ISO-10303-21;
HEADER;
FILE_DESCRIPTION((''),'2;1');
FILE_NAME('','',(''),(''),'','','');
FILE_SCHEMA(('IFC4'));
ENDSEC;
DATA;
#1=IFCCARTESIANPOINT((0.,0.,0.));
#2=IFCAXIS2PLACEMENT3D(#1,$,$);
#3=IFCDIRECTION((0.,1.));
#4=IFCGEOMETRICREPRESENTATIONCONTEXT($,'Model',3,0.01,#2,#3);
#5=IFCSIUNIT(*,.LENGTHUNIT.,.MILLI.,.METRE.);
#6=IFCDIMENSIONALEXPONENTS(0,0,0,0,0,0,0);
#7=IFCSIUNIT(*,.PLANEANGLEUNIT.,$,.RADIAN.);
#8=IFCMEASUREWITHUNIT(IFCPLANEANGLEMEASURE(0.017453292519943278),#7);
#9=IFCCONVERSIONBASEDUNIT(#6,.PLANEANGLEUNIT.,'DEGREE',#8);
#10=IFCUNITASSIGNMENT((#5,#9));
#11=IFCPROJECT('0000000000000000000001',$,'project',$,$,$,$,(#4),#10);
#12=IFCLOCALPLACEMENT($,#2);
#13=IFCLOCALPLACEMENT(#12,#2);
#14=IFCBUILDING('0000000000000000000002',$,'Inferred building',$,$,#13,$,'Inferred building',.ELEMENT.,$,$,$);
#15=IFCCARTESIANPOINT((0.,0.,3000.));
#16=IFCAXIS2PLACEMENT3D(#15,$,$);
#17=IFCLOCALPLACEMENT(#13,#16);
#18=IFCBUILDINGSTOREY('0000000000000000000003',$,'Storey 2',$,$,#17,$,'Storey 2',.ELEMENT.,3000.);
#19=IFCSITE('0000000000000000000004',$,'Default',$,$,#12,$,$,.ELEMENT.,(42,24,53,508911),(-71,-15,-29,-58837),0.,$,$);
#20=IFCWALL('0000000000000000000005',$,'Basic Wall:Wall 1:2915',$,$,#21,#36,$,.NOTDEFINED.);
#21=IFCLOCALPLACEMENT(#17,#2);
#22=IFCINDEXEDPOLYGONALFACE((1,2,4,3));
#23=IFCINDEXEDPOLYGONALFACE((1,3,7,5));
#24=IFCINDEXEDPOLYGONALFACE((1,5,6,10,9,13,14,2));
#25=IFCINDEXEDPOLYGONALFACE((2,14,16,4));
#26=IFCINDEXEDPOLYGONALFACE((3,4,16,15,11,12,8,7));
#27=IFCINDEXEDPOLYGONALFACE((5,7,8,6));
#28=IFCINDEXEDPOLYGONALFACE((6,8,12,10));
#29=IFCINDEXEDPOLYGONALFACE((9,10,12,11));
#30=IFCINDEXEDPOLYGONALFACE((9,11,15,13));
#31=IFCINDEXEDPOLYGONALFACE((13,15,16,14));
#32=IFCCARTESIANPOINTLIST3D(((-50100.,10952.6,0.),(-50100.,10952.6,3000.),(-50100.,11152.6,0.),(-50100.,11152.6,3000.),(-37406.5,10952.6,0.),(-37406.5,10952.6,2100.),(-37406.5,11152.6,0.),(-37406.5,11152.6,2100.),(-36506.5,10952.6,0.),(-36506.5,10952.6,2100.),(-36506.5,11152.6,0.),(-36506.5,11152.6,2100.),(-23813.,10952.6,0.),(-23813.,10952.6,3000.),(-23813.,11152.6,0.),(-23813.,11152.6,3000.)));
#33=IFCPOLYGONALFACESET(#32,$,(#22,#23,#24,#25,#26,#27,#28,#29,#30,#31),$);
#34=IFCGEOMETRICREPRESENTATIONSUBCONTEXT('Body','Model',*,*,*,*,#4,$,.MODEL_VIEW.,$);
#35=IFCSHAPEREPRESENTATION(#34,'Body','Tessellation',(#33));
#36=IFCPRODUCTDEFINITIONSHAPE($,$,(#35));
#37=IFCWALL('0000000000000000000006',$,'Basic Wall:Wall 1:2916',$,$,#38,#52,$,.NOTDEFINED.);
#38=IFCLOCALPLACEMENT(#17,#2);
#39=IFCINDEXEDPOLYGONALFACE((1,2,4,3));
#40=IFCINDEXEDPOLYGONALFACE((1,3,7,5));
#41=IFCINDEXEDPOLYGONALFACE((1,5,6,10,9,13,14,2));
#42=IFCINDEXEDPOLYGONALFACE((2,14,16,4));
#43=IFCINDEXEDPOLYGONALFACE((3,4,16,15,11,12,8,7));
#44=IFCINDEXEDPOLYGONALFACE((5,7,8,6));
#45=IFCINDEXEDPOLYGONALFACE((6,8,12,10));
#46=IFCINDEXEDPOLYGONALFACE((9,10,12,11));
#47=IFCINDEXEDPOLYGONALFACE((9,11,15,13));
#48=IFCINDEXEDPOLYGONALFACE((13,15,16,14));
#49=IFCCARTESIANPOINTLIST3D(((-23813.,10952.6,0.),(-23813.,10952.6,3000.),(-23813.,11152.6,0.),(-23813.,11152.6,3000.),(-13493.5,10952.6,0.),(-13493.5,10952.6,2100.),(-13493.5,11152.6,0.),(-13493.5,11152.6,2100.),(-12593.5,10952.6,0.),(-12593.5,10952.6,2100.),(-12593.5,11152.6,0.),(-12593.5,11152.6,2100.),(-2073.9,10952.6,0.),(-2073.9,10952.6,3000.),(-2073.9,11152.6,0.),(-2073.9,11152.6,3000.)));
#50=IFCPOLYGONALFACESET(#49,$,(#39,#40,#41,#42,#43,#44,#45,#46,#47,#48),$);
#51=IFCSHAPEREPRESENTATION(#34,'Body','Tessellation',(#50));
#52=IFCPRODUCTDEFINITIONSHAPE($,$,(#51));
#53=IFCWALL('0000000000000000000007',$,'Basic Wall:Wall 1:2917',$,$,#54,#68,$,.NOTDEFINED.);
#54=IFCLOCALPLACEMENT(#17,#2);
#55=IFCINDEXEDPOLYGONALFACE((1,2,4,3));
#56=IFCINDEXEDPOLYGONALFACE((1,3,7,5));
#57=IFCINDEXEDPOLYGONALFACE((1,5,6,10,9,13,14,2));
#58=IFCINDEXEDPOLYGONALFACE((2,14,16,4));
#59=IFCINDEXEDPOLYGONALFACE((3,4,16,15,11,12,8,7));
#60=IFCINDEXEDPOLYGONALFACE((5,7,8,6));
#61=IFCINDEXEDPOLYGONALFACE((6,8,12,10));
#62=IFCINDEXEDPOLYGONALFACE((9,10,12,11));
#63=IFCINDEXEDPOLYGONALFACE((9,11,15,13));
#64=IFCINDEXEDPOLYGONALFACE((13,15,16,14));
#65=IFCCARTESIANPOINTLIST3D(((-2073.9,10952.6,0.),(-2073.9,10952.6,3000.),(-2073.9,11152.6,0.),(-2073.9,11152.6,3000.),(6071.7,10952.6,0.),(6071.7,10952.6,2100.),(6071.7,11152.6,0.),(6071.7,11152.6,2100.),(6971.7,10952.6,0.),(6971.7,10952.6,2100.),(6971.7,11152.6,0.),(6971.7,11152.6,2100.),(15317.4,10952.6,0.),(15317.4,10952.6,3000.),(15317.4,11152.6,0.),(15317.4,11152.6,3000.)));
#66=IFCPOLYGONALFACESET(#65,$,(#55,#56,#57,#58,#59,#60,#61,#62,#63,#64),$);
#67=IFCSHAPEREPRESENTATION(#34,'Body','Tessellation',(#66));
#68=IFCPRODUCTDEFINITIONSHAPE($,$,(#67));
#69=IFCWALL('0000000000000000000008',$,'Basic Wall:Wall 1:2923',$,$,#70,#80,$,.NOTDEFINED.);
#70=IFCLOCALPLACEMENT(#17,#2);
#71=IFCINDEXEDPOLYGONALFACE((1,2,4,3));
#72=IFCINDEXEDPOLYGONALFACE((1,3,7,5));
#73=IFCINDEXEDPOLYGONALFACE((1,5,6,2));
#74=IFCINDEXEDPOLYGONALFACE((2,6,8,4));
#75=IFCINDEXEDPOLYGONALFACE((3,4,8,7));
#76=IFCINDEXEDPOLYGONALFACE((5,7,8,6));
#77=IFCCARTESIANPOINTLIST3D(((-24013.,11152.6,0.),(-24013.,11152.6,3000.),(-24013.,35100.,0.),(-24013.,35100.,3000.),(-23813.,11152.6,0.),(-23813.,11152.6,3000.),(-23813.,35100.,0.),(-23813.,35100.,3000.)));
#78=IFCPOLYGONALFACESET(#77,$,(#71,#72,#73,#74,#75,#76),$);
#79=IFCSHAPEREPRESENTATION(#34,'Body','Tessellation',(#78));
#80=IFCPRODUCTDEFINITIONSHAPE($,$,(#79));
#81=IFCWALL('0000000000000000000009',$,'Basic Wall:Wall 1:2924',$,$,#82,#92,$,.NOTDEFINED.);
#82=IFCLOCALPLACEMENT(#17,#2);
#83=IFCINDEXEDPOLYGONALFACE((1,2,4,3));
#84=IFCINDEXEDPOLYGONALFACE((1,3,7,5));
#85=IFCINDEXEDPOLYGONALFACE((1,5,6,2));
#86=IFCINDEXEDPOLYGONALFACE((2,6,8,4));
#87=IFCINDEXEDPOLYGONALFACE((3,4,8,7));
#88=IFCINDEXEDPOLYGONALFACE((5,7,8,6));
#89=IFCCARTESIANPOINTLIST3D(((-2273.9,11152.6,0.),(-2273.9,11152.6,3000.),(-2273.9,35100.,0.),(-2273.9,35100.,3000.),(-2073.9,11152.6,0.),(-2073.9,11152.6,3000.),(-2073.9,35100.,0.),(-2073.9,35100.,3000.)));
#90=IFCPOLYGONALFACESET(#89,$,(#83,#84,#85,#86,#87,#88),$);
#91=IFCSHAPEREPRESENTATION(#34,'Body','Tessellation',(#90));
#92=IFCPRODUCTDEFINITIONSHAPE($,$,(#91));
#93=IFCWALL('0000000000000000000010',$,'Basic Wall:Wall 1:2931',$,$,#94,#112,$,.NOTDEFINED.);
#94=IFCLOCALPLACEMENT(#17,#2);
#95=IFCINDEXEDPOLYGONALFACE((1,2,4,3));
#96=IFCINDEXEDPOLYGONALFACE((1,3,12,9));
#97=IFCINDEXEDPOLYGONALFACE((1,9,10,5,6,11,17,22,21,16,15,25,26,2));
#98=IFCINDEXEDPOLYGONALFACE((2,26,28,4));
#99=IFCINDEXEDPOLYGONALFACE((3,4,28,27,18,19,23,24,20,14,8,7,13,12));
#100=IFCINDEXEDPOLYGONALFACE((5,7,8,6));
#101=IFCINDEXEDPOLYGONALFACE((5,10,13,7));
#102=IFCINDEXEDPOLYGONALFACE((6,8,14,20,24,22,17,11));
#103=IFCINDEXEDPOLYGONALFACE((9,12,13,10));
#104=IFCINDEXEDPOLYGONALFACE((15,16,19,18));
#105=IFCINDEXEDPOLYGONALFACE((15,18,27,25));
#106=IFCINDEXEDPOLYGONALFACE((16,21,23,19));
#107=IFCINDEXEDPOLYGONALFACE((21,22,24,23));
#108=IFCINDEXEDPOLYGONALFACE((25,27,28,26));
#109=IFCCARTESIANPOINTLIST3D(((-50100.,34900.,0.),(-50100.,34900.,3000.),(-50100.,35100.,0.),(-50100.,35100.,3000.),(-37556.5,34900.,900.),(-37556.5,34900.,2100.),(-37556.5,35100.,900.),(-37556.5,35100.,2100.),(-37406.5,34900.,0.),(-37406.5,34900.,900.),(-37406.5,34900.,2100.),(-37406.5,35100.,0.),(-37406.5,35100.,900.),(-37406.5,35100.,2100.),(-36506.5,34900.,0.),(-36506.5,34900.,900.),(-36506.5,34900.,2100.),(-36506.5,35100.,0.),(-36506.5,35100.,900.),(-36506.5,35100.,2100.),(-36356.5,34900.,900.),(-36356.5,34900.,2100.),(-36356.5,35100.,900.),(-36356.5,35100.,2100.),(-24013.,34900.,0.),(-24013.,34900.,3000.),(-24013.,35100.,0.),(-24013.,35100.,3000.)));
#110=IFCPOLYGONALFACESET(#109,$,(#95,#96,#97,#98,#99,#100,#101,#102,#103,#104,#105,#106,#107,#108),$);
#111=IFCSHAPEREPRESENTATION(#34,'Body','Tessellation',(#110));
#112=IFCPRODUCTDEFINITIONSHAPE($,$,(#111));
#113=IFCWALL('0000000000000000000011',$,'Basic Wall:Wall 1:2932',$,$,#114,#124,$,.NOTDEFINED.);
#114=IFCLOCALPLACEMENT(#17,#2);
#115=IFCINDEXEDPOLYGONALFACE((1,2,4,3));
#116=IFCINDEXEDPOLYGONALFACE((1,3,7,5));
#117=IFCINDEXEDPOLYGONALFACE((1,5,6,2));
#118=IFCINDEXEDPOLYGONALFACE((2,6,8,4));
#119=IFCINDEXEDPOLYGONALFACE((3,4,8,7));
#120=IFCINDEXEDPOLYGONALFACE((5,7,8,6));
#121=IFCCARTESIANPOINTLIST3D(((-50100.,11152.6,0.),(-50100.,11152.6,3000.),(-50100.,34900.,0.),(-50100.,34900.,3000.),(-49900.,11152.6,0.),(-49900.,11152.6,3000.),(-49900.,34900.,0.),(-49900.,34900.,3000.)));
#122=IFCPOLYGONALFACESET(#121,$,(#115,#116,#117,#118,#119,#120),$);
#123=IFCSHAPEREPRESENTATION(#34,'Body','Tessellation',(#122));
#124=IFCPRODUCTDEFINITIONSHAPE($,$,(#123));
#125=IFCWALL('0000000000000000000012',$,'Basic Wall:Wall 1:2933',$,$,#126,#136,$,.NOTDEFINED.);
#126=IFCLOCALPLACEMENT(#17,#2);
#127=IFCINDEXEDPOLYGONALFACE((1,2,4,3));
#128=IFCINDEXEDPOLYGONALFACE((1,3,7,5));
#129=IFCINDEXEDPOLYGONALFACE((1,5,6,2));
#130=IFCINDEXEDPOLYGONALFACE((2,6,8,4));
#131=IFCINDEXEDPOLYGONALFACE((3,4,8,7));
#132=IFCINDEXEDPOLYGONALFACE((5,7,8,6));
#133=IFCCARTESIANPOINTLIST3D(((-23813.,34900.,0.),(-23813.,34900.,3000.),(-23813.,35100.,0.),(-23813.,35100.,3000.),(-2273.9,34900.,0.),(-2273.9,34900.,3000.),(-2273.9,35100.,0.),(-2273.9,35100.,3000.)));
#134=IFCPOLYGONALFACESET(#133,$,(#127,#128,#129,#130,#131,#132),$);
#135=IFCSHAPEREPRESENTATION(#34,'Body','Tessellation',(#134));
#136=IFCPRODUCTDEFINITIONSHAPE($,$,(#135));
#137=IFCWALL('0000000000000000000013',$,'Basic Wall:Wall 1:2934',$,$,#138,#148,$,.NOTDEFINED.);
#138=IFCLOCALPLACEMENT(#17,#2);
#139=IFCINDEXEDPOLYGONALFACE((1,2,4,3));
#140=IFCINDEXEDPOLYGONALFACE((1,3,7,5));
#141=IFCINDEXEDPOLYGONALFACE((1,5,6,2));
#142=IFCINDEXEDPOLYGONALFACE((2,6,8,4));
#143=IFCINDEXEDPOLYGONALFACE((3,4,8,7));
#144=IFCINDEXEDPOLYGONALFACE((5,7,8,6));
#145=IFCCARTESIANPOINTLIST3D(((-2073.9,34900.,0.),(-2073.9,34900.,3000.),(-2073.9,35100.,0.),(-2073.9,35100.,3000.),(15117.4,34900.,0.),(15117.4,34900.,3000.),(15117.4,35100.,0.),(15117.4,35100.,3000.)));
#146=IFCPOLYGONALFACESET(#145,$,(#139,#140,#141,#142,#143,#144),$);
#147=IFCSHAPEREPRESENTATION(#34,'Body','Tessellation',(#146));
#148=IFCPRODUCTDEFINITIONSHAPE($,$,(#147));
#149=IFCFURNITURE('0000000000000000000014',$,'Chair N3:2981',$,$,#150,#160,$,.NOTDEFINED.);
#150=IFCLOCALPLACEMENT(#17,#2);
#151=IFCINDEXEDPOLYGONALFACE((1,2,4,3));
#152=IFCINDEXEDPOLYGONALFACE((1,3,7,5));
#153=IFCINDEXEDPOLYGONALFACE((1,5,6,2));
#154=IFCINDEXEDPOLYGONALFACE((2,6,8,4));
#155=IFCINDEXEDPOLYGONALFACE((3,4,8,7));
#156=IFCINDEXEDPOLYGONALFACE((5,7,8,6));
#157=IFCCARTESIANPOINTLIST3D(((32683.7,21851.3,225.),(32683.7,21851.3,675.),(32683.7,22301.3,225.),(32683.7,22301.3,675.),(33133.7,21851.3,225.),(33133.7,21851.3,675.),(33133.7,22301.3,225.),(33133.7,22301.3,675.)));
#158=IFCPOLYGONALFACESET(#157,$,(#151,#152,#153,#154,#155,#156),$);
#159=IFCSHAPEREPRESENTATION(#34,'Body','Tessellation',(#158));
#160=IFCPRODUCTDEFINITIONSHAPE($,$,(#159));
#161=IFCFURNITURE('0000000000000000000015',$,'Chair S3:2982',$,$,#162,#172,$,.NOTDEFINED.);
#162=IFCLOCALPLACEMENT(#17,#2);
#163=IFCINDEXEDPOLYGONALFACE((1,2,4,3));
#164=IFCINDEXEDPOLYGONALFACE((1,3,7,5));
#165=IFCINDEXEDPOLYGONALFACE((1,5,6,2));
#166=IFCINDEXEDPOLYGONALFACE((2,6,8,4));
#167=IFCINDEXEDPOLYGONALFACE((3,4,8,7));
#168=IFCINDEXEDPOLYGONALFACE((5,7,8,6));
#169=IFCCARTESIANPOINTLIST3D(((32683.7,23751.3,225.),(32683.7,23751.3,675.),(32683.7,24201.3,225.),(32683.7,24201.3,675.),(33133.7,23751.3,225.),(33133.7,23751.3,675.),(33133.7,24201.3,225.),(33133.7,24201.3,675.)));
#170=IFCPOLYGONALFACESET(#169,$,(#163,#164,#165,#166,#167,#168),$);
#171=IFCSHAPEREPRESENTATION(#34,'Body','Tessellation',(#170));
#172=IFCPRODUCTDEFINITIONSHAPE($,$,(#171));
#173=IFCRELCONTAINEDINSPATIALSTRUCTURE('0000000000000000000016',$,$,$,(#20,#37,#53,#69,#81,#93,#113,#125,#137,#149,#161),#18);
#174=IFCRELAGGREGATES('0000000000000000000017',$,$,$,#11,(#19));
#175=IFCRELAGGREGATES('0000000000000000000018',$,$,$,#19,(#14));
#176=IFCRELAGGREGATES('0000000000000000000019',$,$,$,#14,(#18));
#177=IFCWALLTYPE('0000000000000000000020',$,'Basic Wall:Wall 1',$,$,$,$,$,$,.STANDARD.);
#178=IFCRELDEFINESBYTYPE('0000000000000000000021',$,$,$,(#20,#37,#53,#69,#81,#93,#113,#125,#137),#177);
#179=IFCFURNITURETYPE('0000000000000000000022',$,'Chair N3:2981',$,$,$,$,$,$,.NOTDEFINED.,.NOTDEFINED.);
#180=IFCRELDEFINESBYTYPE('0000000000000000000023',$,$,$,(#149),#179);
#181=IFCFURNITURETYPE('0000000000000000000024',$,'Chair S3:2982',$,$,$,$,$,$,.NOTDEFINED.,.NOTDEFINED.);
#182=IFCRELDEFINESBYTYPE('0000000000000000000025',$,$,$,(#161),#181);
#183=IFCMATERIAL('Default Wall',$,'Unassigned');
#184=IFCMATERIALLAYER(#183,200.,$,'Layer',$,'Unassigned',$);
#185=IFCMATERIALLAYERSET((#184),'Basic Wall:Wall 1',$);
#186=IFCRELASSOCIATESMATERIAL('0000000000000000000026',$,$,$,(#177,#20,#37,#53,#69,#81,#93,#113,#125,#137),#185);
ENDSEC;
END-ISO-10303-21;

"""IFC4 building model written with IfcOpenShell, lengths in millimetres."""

from ifc_helpers import new_model, entity, si_unit, converted_unit, direction, frame, frame_2d, origin, origin_2d_with_axis, place, context, subcontext, project, spatial, rectangle, extrude, material, layer, layer_set, layer_usage, type_object, element, save


model = new_model("IFC4")

# Units and contexts
model_context = context("Model", 3, precision=0.01, world=origin(), true_north=direction((0.0, 1.0)))
body_context = subcontext(model_context, "Body", "Model", "MODEL_VIEW")
ifc_project = project(units=[si_unit("LENGTHUNIT", "METRE", prefix="MILLI"), converted_unit("PLANEANGLEUNIT", "DEGREE", entity("IfcPlaneAngleMeasure", 0.017453292519943278), si_unit("PLANEANGLEUNIT", "RADIAN"), dimensions=[0, 0, 0, 0, 0, 0, 0])], contexts=[model_context])

# Site, building, storey
site_placement = place(None, origin())
site = spatial("IfcSite", under=ifc_project, at=site_placement, Name="Default", CompositionType="ELEMENT", RefLatitude=(42, 24, 53, 508911), RefLongitude=(-71, -15, -29, -58837), RefElevation=0.0)
building_placement = place(site_placement, origin())
building = spatial("IfcBuilding", under=site, at=building_placement, Name="Inferred building", LongName="Inferred building", CompositionType="ELEMENT")
storey_placement = place(building_placement, frame((0.0, 0.0, 3000.0)))
storey = spatial("IfcBuildingStorey", under=building, at=storey_placement, Name="Storey 2", LongName="Storey 2", CompositionType="ELEMENT", Elevation=3000.0)

# Walls, openings
ifc_material = material(Name="Default Wall", Category="Unassigned")
ifc_layer = layer(ifc_material, 200.0, Name="Layer", Category="Unassigned")
ifc_layer_set = layer_set([ifc_layer], Name="Basic Wall:Wall 1")
ifc_layer_usage_1 = layer_usage(ifc_layer_set, "AXIS2", "NEGATIVE", 100.0)
wall_type = type_object("IfcWallType", Name="Basic Wall:Wall 1", PredefinedType="STANDARD", material=ifc_layer_set)
wall_1_placement = place(storey_placement, frame((-50100.0, 11052.6, 0.0)))
wall_1 = element("IfcWall", 1, at=wall_1_placement, inside=storey, type_object=wall_type, material=ifc_layer_usage_1, Name="Basic Wall:Wall 1:2915", PredefinedType="NOTDEFINED", context=body_context, shape_type="SweptSolid", body=[
    extrude(rectangle(XDim=26287.0, YDim=200.0, at=frame_2d((13143.5, 0.0), x_axis=(1.0, 0.0))), origin(), (0.0, 0.0, 1.0), 3000.0),
])
opening_1_placement = place(wall_1_placement, origin())
element("IfcOpeningElement", 2, at=opening_1_placement, cuts=wall_1, PredefinedType="OPENING", context=body_context, shape_type="SweptSolid", body=[
    extrude(rectangle(XDim=2100.0, YDim=900.0, at=frame_2d((0.0, 0.0), x_axis=(1.0, 0.0))), frame((13143.5, -100.0, 1050.0), z_axis=(0.0, 1.0, 0.0), x_axis=(0.0, 0.0, -1.0)), (0.0, 0.0, 1.0), 200.0),
])
ifc_layer_usage_2 = layer_usage(ifc_layer_set, "AXIS2", "NEGATIVE", 100.0)
wall_2_placement = place(storey_placement, frame((-23813.0, 11052.6, 0.0)))
wall_2 = element("IfcWall", 3, at=wall_2_placement, inside=storey, type_object=wall_type, material=ifc_layer_usage_2, Name="Basic Wall:Wall 1:2916", PredefinedType="NOTDEFINED", context=body_context, shape_type="SweptSolid", body=[
    extrude(rectangle(XDim=21739.1, YDim=200.0, at=frame_2d((10869.6, 0.0), x_axis=(1.0, 0.0))), origin(), (0.0, 0.0, 1.0), 3000.0),
])
opening_2_placement = place(wall_2_placement, origin())
element("IfcOpeningElement", 4, at=opening_2_placement, cuts=wall_2, PredefinedType="OPENING", context=body_context, shape_type="SweptSolid", body=[
    extrude(rectangle(XDim=2100.0, YDim=900.0, at=frame_2d((0.0, 0.0), x_axis=(1.0, 0.0))), frame((10769.6, -100.0, 1050.0), z_axis=(0.0, 1.0, 0.0), x_axis=(0.0, 0.0, -1.0)), (0.0, 0.0, 1.0), 200.0),
])
ifc_layer_usage_3 = layer_usage(ifc_layer_set, "AXIS2", "NEGATIVE", 100.0)
wall_3_placement = place(storey_placement, frame((-2073.9, 11052.6, 0.0)))
wall_3 = element("IfcWall", 5, at=wall_3_placement, inside=storey, type_object=wall_type, material=ifc_layer_usage_3, Name="Basic Wall:Wall 1:2917", PredefinedType="NOTDEFINED", context=body_context, shape_type="SweptSolid", body=[
    extrude(rectangle(XDim=17391.3, YDim=200.0, at=frame_2d((8695.7, 0.0), x_axis=(1.0, 0.0))), origin(), (0.0, 0.0, 1.0), 3000.0),
])
opening_3_placement = place(wall_3_placement, origin())
element("IfcOpeningElement", 6, at=opening_3_placement, cuts=wall_3, PredefinedType="OPENING", context=body_context, shape_type="SweptSolid", body=[
    extrude(rectangle(XDim=2100.0, YDim=900.0, at=frame_2d((0.0, 0.0), x_axis=(1.0, 0.0))), frame((8595.7, -100.0, 1050.0), z_axis=(0.0, 1.0, 0.0), x_axis=(0.0, 0.0, -1.0)), (0.0, 0.0, 1.0), 200.0),
])

# Walls
ifc_layer_usage_4 = layer_usage(ifc_layer_set, "AXIS2", "NEGATIVE", 100.0)
wall_4_placement = place(storey_placement, frame((-23913.0, 11152.6, 0.0), z_axis=(0.0, 0.0, 1.0), x_axis=(0.0, 1.0, 0.0)))
element("IfcWall", 7, at=wall_4_placement, inside=storey, type_object=wall_type, material=ifc_layer_usage_4, Name="Basic Wall:Wall 1:2923", PredefinedType="NOTDEFINED", context=body_context, shape_type="SweptSolid", body=[
    extrude(rectangle(XDim=23947.4, YDim=200.0, at=frame_2d((11973.7, 0.0), x_axis=(-1.0, 0.0))), origin(), (0.0, 0.0, 1.0), 3000.0),
])
ifc_layer_usage_5 = layer_usage(ifc_layer_set, "AXIS2", "NEGATIVE", 100.0)
wall_5_placement = place(storey_placement, frame((-2173.9, 11152.6, 0.0), z_axis=(0.0, 0.0, 1.0), x_axis=(0.0, 1.0, 0.0)))
element("IfcWall", 8, at=wall_5_placement, inside=storey, type_object=wall_type, material=ifc_layer_usage_5, Name="Basic Wall:Wall 1:2924", PredefinedType="NOTDEFINED", context=body_context, shape_type="SweptSolid", body=[
    extrude(rectangle(XDim=23947.4, YDim=200.0, at=frame_2d((11973.7, 0.0), x_axis=(-1.0, 0.0))), origin(), (0.0, 0.0, 1.0), 3000.0),
])

# Wall, openings
ifc_layer_usage_6 = layer_usage(ifc_layer_set, "AXIS2", "NEGATIVE", 100.0)
wall_6_placement = place(storey_placement, frame((-50100.0, 35000.0, 0.0)))
wall_6 = element("IfcWall", 9, at=wall_6_placement, inside=storey, type_object=wall_type, material=ifc_layer_usage_6, Name="Basic Wall:Wall 1:2931", PredefinedType="NOTDEFINED", context=body_context, shape_type="SweptSolid", body=[
    extrude(rectangle(XDim=26087.0, YDim=200.0, at=frame_2d((13043.5, 0.0), x_axis=(1.0, 0.0))), origin(), (0.0, 0.0, 1.0), 3000.0),
])
opening_4_placement = place(wall_6_placement, origin())
element("IfcOpeningElement", 10, at=opening_4_placement, cuts=wall_6, PredefinedType="OPENING", context=body_context, shape_type="SweptSolid", body=[
    extrude(rectangle(XDim=2100.0, YDim=900.0, at=frame_2d((0.0, 0.0), x_axis=(1.0, 0.0))), frame((13143.5, -100.0, 1050.0), z_axis=(0.0, 1.0, 0.0), x_axis=(0.0, 0.0, -1.0)), (0.0, 0.0, 1.0), 200.0),
])
opening_5_placement = place(wall_6_placement, origin())
element("IfcOpeningElement", 11, at=opening_5_placement, cuts=wall_6, PredefinedType="OPENING", context=body_context, shape_type="SweptSolid", body=[
    extrude(rectangle(XDim=1200.0, YDim=1200.0, at=frame_2d((0.0, 0.0), x_axis=(1.0, 0.0))), frame((13143.5, -100.0, 1500.0), z_axis=(0.0, 1.0, 0.0), x_axis=(0.0, 0.0, -1.0)), (0.0, 0.0, 1.0), 200.0),
])

# Walls
ifc_layer_usage_7 = layer_usage(ifc_layer_set, "AXIS2", "NEGATIVE", 100.0)
wall_7_placement = place(storey_placement, frame((-50000.0, 11152.6, 0.0), z_axis=(0.0, 0.0, 1.0), x_axis=(0.0, 1.0, 0.0)))
element("IfcWall", 12, at=wall_7_placement, inside=storey, type_object=wall_type, material=ifc_layer_usage_7, Name="Basic Wall:Wall 1:2932", PredefinedType="NOTDEFINED", context=body_context, shape_type="SweptSolid", body=[
    extrude(rectangle(XDim=23747.4, YDim=200.0, at=frame_2d((11873.7, 0.0), x_axis=(-1.0, 0.0))), origin(), (0.0, 0.0, 1.0), 3000.0),
])
ifc_layer_usage_8 = layer_usage(ifc_layer_set, "AXIS2", "NEGATIVE", 100.0)
wall_8_placement = place(storey_placement, frame((-23813.0, 35000.0, 0.0)))
element("IfcWall", 13, at=wall_8_placement, inside=storey, type_object=wall_type, material=ifc_layer_usage_8, Name="Basic Wall:Wall 1:2933", PredefinedType="NOTDEFINED", context=body_context, shape_type="SweptSolid", body=[
    extrude(rectangle(XDim=21539.1, YDim=200.0, at=frame_2d((10769.6, 0.0), x_axis=(-1.0, 0.0))), origin(), (0.0, 0.0, 1.0), 3000.0),
])
ifc_layer_usage_9 = layer_usage(ifc_layer_set, "AXIS2", "NEGATIVE", 100.0)
wall_9_placement = place(storey_placement, frame((-2073.9, 35000.0, 0.0)))
element("IfcWall", 14, at=wall_9_placement, inside=storey, type_object=wall_type, material=ifc_layer_usage_9, Name="Basic Wall:Wall 1:2934", PredefinedType="NOTDEFINED", context=body_context, shape_type="SweptSolid", body=[
    extrude(rectangle(XDim=17191.3, YDim=200.0, at=frame_2d((8595.7, 0.0), x_axis=(-1.0, 0.0))), origin(), (0.0, 0.0, 1.0), 3000.0),
])

# Furniture
furniture_type_1 = type_object("IfcFurnitureType", Name="Chair N3:2981", PredefinedType="NOTDEFINED")
furniture_1_placement = place(storey_placement, origin())
element("IfcFurniture", 15, at=furniture_1_placement, inside=storey, type_object=furniture_type_1, Name="Chair N3:2981", PredefinedType="NOTDEFINED", context=body_context, shape_type="SweptSolid", body=[
    extrude(rectangle(XDim=450.0, YDim=450.0, at=origin_2d_with_axis()), frame((32908.7, 22076.3, 225.0)), (0.0, 0.0, 1.0), 450.0),
])
furniture_type_2 = type_object("IfcFurnitureType", Name="Chair S3:2982", PredefinedType="NOTDEFINED")
furniture_2_placement = place(storey_placement, origin())
element("IfcFurniture", 16, at=furniture_2_placement, inside=storey, type_object=furniture_type_2, Name="Chair S3:2982", PredefinedType="NOTDEFINED", context=body_context, shape_type="SweptSolid", body=[
    extrude(rectangle(XDim=450.0, YDim=450.0, at=origin_2d_with_axis()), frame((32908.7, 23976.3, 225.0)), (0.0, 0.0, 1.0), 450.0),
])

save(model, "model.ifc")
